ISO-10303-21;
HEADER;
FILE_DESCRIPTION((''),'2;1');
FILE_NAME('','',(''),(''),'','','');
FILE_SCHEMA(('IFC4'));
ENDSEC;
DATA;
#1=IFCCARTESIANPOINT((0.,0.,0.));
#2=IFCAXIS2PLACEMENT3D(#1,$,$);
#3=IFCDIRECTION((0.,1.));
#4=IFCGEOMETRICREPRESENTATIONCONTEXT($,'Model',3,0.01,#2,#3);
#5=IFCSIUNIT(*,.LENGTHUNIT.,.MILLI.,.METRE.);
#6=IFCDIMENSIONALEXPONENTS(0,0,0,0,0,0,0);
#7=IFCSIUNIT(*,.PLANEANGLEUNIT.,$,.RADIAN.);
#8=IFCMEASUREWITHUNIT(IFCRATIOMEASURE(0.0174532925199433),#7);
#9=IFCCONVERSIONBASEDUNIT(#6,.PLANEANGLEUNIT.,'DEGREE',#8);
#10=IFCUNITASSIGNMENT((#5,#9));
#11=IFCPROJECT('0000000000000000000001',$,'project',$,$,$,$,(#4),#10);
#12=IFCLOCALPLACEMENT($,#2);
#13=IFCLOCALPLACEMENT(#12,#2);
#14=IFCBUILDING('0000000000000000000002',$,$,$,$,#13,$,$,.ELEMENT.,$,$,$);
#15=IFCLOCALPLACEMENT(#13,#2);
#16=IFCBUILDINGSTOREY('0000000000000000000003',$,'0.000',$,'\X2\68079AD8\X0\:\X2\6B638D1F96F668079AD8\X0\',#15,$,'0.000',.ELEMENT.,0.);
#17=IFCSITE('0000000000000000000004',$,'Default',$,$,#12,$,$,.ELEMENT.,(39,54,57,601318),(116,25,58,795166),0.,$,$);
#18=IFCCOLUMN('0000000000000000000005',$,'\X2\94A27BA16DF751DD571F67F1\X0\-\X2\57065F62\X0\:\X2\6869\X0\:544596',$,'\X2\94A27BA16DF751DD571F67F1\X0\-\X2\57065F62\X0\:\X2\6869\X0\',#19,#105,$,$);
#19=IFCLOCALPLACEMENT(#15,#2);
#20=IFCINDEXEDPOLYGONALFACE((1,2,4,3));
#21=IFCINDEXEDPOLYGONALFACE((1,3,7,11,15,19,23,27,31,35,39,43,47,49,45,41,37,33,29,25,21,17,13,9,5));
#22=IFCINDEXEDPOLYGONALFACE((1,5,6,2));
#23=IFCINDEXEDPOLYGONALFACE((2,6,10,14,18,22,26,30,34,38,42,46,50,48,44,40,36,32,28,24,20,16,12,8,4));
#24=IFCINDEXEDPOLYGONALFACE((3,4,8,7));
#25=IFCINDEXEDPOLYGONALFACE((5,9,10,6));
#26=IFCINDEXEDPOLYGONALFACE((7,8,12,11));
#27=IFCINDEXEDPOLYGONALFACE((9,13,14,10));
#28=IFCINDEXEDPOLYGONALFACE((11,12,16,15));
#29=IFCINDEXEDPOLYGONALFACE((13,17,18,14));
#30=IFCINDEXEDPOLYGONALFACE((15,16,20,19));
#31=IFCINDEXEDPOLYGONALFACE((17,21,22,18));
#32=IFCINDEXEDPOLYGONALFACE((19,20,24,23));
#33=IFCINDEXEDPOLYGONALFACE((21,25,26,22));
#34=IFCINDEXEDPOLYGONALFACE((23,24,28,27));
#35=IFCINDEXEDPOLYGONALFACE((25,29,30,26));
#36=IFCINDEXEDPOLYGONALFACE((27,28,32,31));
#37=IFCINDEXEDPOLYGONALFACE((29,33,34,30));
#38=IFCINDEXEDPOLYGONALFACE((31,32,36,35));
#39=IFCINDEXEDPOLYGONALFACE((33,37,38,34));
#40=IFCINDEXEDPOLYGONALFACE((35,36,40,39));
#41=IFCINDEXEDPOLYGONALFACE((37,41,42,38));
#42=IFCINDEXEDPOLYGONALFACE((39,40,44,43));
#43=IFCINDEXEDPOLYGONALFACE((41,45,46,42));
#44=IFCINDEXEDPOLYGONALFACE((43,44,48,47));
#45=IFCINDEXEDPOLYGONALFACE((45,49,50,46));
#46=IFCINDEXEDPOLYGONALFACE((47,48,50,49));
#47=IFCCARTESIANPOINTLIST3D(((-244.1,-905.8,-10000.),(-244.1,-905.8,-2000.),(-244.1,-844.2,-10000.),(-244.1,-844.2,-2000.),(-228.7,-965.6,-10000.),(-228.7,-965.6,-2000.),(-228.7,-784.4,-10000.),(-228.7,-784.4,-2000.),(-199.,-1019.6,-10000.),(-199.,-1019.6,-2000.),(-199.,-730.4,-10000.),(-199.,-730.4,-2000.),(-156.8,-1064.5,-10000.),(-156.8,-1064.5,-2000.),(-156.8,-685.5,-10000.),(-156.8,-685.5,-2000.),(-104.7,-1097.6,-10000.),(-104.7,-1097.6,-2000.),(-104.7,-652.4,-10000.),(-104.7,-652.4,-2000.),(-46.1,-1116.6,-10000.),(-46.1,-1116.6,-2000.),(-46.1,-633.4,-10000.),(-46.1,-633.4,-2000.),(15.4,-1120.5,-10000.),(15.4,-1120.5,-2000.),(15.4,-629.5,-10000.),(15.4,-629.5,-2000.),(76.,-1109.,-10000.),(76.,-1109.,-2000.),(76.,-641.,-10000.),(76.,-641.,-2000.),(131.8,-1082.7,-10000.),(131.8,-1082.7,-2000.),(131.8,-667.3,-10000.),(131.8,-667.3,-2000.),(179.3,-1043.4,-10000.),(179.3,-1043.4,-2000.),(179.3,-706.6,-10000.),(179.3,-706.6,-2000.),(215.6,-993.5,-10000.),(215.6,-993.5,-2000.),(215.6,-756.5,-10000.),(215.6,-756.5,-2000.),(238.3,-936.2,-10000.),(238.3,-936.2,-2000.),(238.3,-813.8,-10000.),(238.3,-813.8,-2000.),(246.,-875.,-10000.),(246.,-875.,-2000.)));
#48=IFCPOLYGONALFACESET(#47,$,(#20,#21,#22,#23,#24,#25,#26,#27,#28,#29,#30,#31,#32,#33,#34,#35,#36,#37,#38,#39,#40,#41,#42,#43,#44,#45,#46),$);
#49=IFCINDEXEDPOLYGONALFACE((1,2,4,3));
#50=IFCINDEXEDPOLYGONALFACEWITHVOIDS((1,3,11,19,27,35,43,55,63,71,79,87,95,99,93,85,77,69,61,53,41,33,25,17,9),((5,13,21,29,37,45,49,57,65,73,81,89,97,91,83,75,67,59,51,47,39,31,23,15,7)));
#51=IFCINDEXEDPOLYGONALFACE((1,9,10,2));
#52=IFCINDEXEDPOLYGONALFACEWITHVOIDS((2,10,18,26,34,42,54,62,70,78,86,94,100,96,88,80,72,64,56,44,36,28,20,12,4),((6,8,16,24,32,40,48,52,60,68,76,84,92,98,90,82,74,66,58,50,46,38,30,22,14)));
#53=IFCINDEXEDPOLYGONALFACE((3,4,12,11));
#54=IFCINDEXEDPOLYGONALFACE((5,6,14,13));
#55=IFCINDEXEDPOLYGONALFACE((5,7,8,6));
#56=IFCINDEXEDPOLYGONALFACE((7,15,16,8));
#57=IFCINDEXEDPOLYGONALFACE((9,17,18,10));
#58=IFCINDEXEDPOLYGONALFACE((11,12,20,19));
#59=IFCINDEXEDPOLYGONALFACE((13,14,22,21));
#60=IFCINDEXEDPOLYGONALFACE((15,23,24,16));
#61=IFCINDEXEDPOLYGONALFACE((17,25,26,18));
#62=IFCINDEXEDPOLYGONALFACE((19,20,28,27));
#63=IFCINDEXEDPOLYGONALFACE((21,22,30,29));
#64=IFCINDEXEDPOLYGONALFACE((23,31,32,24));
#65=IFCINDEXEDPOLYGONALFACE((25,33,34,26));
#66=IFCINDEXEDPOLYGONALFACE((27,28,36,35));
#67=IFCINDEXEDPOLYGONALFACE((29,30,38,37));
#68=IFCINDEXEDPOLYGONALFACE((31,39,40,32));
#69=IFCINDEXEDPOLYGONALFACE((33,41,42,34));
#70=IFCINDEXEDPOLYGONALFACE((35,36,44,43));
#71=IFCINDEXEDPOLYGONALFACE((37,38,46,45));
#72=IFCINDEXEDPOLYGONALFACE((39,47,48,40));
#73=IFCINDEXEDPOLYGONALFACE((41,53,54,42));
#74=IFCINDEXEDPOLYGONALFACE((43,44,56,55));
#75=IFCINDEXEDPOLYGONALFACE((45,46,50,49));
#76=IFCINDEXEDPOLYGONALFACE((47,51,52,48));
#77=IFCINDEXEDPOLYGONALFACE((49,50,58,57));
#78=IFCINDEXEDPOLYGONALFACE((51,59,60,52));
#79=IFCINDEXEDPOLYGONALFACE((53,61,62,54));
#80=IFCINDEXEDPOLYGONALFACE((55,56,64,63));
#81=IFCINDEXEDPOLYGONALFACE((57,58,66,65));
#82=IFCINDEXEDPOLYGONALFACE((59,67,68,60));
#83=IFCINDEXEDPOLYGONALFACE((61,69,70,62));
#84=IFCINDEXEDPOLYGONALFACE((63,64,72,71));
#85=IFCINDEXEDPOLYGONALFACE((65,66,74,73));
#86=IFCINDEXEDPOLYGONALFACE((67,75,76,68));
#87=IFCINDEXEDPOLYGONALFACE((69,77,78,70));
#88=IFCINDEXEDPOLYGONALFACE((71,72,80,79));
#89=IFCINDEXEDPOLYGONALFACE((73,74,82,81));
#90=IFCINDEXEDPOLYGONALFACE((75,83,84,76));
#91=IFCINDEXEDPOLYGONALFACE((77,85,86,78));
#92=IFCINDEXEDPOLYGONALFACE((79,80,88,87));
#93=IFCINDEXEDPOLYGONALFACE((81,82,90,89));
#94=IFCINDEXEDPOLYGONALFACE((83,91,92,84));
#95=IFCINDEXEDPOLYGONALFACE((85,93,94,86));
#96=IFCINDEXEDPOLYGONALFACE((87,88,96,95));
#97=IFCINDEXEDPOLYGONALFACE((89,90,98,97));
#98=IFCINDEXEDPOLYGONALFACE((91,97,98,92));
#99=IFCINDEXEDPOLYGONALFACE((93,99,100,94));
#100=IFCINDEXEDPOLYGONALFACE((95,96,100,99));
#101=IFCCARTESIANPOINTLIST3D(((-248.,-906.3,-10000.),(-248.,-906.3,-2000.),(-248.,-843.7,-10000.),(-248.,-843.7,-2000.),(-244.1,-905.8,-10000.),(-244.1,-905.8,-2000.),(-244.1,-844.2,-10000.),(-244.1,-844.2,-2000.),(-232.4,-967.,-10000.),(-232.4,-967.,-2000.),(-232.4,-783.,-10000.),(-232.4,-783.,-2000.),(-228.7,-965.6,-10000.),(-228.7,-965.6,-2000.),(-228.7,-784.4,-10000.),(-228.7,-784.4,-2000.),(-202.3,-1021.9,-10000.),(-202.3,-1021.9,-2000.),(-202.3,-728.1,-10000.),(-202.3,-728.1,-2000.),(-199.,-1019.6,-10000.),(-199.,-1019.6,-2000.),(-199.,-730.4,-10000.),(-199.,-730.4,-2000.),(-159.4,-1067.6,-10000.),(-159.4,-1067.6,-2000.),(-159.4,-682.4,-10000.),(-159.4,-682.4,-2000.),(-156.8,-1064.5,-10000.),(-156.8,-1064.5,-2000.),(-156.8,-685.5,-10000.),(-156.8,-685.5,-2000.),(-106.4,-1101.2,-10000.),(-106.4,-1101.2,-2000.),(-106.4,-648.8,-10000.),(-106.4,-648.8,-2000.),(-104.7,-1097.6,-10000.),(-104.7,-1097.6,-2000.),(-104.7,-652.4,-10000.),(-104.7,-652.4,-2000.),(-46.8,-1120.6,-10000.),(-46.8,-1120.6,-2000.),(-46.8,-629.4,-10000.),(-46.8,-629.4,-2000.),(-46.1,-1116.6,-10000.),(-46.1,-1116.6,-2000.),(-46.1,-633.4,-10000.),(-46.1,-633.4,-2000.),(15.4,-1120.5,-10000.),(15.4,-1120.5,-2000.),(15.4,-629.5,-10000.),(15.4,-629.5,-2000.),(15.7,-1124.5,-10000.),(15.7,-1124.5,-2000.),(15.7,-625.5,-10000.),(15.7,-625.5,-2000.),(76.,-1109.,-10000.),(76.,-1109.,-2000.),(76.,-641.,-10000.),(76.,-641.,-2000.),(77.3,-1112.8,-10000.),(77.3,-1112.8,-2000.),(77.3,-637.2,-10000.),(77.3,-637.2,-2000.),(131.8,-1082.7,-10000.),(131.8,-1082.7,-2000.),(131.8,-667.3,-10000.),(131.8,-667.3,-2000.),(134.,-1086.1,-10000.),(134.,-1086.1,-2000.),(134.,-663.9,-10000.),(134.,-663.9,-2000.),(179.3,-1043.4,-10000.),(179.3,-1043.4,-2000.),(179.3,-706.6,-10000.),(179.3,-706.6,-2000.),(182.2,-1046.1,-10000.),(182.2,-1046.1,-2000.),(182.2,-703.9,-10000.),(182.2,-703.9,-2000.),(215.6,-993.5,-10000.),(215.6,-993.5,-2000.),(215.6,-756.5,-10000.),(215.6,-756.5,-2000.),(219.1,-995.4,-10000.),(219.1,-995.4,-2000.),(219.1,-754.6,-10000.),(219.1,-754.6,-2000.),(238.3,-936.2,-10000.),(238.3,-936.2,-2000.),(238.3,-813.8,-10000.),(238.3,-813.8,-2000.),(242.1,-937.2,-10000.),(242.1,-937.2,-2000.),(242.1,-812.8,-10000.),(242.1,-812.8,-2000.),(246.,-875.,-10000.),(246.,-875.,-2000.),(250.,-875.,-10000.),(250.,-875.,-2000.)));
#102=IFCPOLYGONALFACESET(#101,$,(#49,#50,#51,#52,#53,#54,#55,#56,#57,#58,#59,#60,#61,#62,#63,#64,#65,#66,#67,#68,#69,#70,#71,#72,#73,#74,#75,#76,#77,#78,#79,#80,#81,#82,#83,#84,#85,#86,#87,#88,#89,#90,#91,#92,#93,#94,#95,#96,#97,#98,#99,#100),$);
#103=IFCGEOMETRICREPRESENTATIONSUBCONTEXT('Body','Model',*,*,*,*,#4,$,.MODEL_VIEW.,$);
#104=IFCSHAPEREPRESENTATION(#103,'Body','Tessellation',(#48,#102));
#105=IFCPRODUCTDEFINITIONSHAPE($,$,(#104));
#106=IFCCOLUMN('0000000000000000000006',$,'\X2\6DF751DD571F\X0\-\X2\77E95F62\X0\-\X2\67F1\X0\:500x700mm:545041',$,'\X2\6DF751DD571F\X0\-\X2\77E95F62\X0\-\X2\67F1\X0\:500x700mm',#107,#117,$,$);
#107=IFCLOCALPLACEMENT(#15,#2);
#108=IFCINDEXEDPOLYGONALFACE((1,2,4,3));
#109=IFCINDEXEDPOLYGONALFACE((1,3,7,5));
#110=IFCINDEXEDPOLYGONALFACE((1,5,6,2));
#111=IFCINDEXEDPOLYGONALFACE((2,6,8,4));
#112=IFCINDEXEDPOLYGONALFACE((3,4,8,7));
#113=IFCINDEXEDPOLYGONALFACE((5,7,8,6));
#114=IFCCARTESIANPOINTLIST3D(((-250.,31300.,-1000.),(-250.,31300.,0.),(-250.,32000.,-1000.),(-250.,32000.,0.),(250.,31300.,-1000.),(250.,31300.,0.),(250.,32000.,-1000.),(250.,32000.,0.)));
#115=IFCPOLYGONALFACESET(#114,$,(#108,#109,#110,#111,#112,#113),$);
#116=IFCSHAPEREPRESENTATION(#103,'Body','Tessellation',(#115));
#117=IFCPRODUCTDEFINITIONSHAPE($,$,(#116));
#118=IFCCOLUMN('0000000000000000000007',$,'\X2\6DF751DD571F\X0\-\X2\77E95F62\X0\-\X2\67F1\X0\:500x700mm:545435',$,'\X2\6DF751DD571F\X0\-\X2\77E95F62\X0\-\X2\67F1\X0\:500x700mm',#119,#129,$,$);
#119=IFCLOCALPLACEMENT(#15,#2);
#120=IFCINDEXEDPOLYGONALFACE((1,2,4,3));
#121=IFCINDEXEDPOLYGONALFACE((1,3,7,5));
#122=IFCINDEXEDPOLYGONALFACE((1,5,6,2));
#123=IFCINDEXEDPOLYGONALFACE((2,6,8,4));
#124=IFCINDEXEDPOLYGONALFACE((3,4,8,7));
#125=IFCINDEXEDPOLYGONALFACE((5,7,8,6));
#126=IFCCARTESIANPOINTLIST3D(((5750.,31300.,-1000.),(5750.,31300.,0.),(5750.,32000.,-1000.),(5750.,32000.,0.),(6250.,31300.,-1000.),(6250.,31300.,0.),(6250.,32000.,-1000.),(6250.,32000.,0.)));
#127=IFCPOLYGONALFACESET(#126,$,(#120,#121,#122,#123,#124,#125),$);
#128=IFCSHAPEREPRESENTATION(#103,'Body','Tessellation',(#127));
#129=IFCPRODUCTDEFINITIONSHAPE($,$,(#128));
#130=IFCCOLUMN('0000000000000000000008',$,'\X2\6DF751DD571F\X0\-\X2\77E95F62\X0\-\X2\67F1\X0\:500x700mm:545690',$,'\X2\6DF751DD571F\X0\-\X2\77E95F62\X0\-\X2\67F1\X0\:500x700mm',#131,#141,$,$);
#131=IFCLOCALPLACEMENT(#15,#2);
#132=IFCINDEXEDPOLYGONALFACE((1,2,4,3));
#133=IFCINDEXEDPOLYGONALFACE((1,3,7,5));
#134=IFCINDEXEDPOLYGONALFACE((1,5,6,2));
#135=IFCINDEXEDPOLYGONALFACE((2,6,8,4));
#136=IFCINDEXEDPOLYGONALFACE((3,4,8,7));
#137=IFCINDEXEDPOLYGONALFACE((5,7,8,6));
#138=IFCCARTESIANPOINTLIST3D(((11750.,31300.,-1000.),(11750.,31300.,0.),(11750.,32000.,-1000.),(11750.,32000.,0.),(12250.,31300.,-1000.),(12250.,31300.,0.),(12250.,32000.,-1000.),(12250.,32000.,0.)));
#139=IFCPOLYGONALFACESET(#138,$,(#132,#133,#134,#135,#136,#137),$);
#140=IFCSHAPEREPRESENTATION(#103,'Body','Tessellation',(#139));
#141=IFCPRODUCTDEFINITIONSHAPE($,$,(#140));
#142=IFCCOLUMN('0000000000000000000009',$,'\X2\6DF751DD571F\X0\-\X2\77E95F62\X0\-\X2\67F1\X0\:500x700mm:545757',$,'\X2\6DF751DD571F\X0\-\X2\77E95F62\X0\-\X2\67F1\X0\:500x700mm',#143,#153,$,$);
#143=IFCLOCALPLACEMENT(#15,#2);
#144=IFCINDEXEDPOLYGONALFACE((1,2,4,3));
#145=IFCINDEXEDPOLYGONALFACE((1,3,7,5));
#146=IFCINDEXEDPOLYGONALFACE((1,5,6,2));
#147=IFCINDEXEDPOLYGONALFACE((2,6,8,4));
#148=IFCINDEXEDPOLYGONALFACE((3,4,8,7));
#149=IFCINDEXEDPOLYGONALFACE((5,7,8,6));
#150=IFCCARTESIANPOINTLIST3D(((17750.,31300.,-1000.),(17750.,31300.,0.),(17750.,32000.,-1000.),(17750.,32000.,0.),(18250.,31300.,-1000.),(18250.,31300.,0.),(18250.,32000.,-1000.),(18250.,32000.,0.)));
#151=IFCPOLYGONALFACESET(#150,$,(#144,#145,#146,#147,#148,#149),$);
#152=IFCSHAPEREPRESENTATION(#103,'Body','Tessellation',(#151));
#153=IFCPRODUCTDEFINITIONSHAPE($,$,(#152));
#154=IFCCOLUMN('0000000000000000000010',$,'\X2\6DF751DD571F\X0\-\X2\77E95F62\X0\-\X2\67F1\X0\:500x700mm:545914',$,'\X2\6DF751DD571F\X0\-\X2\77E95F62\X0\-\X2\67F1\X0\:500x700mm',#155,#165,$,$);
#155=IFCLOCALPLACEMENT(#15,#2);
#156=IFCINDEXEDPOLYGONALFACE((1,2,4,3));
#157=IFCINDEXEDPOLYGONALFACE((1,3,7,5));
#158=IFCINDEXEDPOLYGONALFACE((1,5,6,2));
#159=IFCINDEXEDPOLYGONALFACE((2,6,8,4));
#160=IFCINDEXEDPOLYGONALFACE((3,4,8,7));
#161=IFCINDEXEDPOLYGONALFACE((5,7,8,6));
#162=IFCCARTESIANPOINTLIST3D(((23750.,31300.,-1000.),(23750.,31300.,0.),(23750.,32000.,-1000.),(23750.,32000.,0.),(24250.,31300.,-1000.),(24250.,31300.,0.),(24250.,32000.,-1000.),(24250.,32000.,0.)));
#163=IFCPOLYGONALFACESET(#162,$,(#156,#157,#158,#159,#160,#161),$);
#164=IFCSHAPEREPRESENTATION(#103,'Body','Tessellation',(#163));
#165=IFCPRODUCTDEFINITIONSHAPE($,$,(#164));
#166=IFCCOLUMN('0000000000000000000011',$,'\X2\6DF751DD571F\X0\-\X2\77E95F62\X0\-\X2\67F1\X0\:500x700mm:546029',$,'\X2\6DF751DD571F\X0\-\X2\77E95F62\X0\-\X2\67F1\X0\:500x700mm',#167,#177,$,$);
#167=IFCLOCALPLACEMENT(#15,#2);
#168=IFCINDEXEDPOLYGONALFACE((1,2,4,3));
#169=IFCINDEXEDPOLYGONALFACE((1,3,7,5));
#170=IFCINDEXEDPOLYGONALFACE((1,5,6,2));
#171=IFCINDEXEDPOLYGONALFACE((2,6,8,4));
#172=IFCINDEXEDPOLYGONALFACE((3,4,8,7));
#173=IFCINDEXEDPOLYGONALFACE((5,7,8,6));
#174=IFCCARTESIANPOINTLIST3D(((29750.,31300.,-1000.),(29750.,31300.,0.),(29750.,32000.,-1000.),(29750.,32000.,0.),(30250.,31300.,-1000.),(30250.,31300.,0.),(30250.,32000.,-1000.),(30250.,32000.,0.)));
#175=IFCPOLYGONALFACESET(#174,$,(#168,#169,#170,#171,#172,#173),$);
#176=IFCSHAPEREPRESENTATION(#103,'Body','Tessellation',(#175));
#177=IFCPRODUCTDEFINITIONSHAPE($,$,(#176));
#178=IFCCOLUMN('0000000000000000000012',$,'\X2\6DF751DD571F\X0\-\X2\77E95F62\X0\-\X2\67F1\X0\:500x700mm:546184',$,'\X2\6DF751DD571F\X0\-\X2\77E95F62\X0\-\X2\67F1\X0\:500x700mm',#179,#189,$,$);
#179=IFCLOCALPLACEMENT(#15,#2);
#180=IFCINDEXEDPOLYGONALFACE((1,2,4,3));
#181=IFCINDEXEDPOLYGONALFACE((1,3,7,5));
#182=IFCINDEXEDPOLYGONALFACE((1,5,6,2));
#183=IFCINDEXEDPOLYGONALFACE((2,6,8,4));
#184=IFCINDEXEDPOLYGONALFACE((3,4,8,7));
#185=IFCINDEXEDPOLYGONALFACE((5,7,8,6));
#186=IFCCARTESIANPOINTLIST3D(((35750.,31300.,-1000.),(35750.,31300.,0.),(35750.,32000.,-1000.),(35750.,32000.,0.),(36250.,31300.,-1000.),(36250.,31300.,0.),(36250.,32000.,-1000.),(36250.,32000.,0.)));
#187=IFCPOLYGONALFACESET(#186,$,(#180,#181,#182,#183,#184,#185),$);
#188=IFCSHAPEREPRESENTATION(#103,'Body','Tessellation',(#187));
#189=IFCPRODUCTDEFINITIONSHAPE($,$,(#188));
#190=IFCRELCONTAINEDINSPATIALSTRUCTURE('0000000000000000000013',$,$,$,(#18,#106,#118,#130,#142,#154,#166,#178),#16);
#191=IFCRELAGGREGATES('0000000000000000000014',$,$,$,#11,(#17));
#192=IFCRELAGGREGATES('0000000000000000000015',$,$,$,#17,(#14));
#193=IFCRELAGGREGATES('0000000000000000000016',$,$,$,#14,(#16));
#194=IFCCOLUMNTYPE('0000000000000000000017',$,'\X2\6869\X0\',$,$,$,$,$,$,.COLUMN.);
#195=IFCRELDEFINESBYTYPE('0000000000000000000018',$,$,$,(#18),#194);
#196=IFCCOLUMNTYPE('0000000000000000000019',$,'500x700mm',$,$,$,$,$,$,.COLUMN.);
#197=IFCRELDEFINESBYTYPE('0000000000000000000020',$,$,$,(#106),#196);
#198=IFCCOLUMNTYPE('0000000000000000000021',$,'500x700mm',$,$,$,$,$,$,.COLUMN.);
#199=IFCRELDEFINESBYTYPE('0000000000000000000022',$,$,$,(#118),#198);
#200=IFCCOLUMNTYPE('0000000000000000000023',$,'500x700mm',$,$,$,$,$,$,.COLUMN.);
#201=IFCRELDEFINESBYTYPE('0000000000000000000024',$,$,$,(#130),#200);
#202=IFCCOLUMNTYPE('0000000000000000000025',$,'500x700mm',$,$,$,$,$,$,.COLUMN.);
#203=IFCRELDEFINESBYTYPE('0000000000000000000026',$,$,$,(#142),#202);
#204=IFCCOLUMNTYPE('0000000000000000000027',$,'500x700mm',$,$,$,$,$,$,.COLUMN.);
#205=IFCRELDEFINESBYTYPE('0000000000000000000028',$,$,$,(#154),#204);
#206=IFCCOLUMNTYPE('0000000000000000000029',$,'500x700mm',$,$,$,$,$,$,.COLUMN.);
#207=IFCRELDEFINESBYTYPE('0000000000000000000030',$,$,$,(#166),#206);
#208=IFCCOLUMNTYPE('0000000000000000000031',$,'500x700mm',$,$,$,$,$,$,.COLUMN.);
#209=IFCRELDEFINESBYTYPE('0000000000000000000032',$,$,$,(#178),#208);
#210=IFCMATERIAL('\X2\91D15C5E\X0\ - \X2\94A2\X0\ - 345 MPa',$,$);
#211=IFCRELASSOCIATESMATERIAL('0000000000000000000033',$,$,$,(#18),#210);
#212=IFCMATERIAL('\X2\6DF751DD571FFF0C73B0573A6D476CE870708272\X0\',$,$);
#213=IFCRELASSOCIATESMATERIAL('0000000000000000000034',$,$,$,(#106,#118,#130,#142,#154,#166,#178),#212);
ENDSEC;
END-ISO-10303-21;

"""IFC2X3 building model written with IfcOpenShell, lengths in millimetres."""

from ifc_helpers import new_model, entity, si_unit, converted_unit, direction, frame, frame_2d, origin, origin_2d_with_axis, place, context, subcontext, project, spatial, rectangle, circle, hollow_circle, extrude, source, transform, mapped, material, type_object, type_shapes, element, save


model = new_model("IFC2X3")

# Units and contexts
model_context = context("Model", 3, precision=0.01, world=origin(), true_north=direction((0.0, 1.0)))
body_context = subcontext(model_context, "Body", "Model", "MODEL_VIEW")
ifc_project = project(units=[si_unit("LENGTHUNIT", "METRE", prefix="MILLI"), converted_unit("PLANEANGLEUNIT", "DEGREE", entity("IfcRatioMeasure", 0.0174532925199433), si_unit("PLANEANGLEUNIT", "RADIAN"), dimensions=[0, 0, 0, 0, 0, 0, 0])], contexts=[model_context])

# Site, building, storey
site_placement = place(None, origin())
site = spatial("IfcSite", under=ifc_project, at=site_placement, Name="Default", CompositionType="ELEMENT", RefLatitude=(39, 54, 57, 601318), RefLongitude=(116, 25, 58, 795166), RefElevation=0.0)
building_placement = place(site_placement, origin())
building = spatial("IfcBuilding", under=site, at=building_placement, CompositionType="ELEMENT")
storey_placement = place(building_placement, origin())
storey = spatial("IfcBuildingStorey", under=building, at=storey_placement, Name="0.000", ObjectType="标高:正负零标高", LongName="0.000", CompositionType="ELEMENT", Elevation=0.0)

# Columns
ifc_material_1 = material(Name="金属 - 钢 - 345 MPa")
column_type_1 = type_object("IfcColumnType", Name="桩", PredefinedType="COLUMN")
shared_shape_1 = source(origin(), body_context, "Body", "SweptSolid", [
    extrude(circle(Radius=246.0, at=frame_2d((0.0, 0.0), x_axis=(1.0, 0.0))), frame((0.0, 0.0, -10000.0)), (0.0, 0.0, 1.0), 8000.0),
    extrude(hollow_circle(Radius=250.0, WallThickness=4.0, at=frame_2d((0.0, 0.0), x_axis=(1.0, 0.0))), frame((0.0, 0.0, -10000.0)), (0.0, 0.0, 1.0), 8000.0),
])
type_shapes(column_type_1, [shared_shape_1])
column_1_placement = place(storey_placement, frame((0.0, -875.0, 0.0)))
element("IfcColumn", 1, at=column_1_placement, inside=storey, type_object=column_type_1, material=ifc_material_1, Name="钢管混凝土柱-圆形:桩:544596", ObjectType="钢管混凝土柱-圆形:桩", context=body_context, shape_type="MappedRepresentation", body=[
    mapped(shared_shape_1, transform((0.0, 0.0, 0.0), scale=1.0)),
])
ifc_material_2 = material(Name="混凝土，现场浇注灰色")
column_type_2 = type_object("IfcColumnType", Name="500x700mm", PredefinedType="COLUMN")
shared_shape_2 = source(origin(), body_context, "Body", "SweptSolid", [
    extrude(rectangle(XDim=700.0, YDim=500.0, at=origin_2d_with_axis()), frame((0.0, 31650.0, -1000.0), z_axis=(0.0, 0.0, 1.0), x_axis=(0.0, -1.0, 0.0)), (0.0, 0.0, 1.0), 1000.0),
])
type_shapes(column_type_2, [shared_shape_2])
column_2_placement = place(storey_placement, origin())
element("IfcColumn", 2, at=column_2_placement, inside=storey, type_object=column_type_2, material=ifc_material_2, Name="混凝土-矩形-柱:500x700mm:545041", ObjectType="混凝土-矩形-柱:500x700mm", context=body_context, shape_type="MappedRepresentation", body=[
    mapped(shared_shape_2, transform((0.0, 0.0, 0.0), scale=1.0)),
])
column_type_3 = type_object("IfcColumnType", Name="500x700mm", PredefinedType="COLUMN")
shared_shape_3 = source(origin(), body_context, "Body", "SweptSolid", [
    extrude(rectangle(XDim=700.0, YDim=500.0, at=frame_2d((0.0, 0.0), x_axis=(1.0, 0.0))), frame((6000.0, 31650.0, -1000.0), z_axis=(0.0, 0.0, 1.0), x_axis=(0.0, -1.0, 0.0)), (0.0, 0.0, 1.0), 1000.0),
])
type_shapes(column_type_3, [shared_shape_3])
column_3_placement = place(storey_placement, origin())
element("IfcColumn", 3, at=column_3_placement, inside=storey, type_object=column_type_3, material=ifc_material_2, Name="混凝土-矩形-柱:500x700mm:545435", ObjectType="混凝土-矩形-柱:500x700mm", context=body_context, shape_type="MappedRepresentation", body=[
    mapped(shared_shape_3, transform((0.0, 0.0, 0.0), scale=1.0)),
])
column_type_4 = type_object("IfcColumnType", Name="500x700mm", PredefinedType="COLUMN")
shared_shape_4 = source(origin(), body_context, "Body", "SweptSolid", [
    extrude(rectangle(XDim=700.0, YDim=500.0, at=origin_2d_with_axis()), frame((12000.0, 31650.0, -1000.0), z_axis=(0.0, 0.0, 1.0), x_axis=(0.0, -1.0, 0.0)), (0.0, 0.0, 1.0), 1000.0),
])
type_shapes(column_type_4, [shared_shape_4])
column_4_placement = place(storey_placement, origin())
element("IfcColumn", 4, at=column_4_placement, inside=storey, type_object=column_type_4, material=ifc_material_2, Name="混凝土-矩形-柱:500x700mm:545690", ObjectType="混凝土-矩形-柱:500x700mm", context=body_context, shape_type="MappedRepresentation", body=[
    mapped(shared_shape_4, transform((0.0, 0.0, 0.0), scale=1.0)),
])
column_type_5 = type_object("IfcColumnType", Name="500x700mm", PredefinedType="COLUMN")
shared_shape_5 = source(origin(), body_context, "Body", "SweptSolid", [
    extrude(rectangle(XDim=700.0, YDim=500.0, at=origin_2d_with_axis()), frame((18000.0, 31650.0, -1000.0), z_axis=(0.0, 0.0, 1.0), x_axis=(0.0, -1.0, 0.0)), (0.0, 0.0, 1.0), 1000.0),
])
type_shapes(column_type_5, [shared_shape_5])
column_5_placement = place(storey_placement, origin())
element("IfcColumn", 5, at=column_5_placement, inside=storey, type_object=column_type_5, material=ifc_material_2, Name="混凝土-矩形-柱:500x700mm:545757", ObjectType="混凝土-矩形-柱:500x700mm", context=body_context, shape_type="MappedRepresentation", body=[
    mapped(shared_shape_5, transform((0.0, 0.0, 0.0), scale=1.0)),
])
column_type_6 = type_object("IfcColumnType", Name="500x700mm", PredefinedType="COLUMN")
shared_shape_6 = source(origin(), body_context, "Body", "SweptSolid", [
    extrude(rectangle(XDim=700.0, YDim=500.0, at=origin_2d_with_axis()), frame((24000.0, 31650.0, -1000.0), z_axis=(0.0, 0.0, 1.0), x_axis=(0.0, -1.0, 0.0)), (0.0, 0.0, 1.0), 1000.0),
])
type_shapes(column_type_6, [shared_shape_6])
column_6_placement = place(storey_placement, origin())
element("IfcColumn", 6, at=column_6_placement, inside=storey, type_object=column_type_6, material=ifc_material_2, Name="混凝土-矩形-柱:500x700mm:545914", ObjectType="混凝土-矩形-柱:500x700mm", context=body_context, shape_type="MappedRepresentation", body=[
    mapped(shared_shape_6, transform((0.0, 0.0, 0.0), scale=1.0)),
])
column_type_7 = type_object("IfcColumnType", Name="500x700mm", PredefinedType="COLUMN")
shared_shape_7 = source(origin(), body_context, "Body", "SweptSolid", [
    extrude(rectangle(XDim=700.0, YDim=500.0, at=origin_2d_with_axis()), frame((30000.0, 31650.0, -1000.0), z_axis=(0.0, 0.0, 1.0), x_axis=(0.0, -1.0, 0.0)), (0.0, 0.0, 1.0), 1000.0),
])
type_shapes(column_type_7, [shared_shape_7])
column_7_placement = place(storey_placement, origin())
element("IfcColumn", 7, at=column_7_placement, inside=storey, type_object=column_type_7, material=ifc_material_2, Name="混凝土-矩形-柱:500x700mm:546029", ObjectType="混凝土-矩形-柱:500x700mm", context=body_context, shape_type="MappedRepresentation", body=[
    mapped(shared_shape_7, transform((0.0, 0.0, 0.0), scale=1.0)),
])
column_type_8 = type_object("IfcColumnType", Name="500x700mm", PredefinedType="COLUMN")
shared_shape_8 = source(origin(), body_context, "Body", "SweptSolid", [
    extrude(rectangle(XDim=700.0, YDim=500.0, at=origin_2d_with_axis()), frame((36000.0, 31650.0, -1000.0), z_axis=(0.0, 0.0, 1.0), x_axis=(0.0, -1.0, 0.0)), (0.0, 0.0, 1.0), 1000.0),
])
type_shapes(column_type_8, [shared_shape_8])
column_8_placement = place(storey_placement, origin())
element("IfcColumn", 8, at=column_8_placement, inside=storey, type_object=column_type_8, material=ifc_material_2, Name="混凝土-矩形-柱:500x700mm:546184", ObjectType="混凝土-矩形-柱:500x700mm", context=body_context, shape_type="MappedRepresentation", body=[
    mapped(shared_shape_8, transform((0.0, 0.0, 0.0), scale=1.0)),
])

save(model, "model.ifc")
